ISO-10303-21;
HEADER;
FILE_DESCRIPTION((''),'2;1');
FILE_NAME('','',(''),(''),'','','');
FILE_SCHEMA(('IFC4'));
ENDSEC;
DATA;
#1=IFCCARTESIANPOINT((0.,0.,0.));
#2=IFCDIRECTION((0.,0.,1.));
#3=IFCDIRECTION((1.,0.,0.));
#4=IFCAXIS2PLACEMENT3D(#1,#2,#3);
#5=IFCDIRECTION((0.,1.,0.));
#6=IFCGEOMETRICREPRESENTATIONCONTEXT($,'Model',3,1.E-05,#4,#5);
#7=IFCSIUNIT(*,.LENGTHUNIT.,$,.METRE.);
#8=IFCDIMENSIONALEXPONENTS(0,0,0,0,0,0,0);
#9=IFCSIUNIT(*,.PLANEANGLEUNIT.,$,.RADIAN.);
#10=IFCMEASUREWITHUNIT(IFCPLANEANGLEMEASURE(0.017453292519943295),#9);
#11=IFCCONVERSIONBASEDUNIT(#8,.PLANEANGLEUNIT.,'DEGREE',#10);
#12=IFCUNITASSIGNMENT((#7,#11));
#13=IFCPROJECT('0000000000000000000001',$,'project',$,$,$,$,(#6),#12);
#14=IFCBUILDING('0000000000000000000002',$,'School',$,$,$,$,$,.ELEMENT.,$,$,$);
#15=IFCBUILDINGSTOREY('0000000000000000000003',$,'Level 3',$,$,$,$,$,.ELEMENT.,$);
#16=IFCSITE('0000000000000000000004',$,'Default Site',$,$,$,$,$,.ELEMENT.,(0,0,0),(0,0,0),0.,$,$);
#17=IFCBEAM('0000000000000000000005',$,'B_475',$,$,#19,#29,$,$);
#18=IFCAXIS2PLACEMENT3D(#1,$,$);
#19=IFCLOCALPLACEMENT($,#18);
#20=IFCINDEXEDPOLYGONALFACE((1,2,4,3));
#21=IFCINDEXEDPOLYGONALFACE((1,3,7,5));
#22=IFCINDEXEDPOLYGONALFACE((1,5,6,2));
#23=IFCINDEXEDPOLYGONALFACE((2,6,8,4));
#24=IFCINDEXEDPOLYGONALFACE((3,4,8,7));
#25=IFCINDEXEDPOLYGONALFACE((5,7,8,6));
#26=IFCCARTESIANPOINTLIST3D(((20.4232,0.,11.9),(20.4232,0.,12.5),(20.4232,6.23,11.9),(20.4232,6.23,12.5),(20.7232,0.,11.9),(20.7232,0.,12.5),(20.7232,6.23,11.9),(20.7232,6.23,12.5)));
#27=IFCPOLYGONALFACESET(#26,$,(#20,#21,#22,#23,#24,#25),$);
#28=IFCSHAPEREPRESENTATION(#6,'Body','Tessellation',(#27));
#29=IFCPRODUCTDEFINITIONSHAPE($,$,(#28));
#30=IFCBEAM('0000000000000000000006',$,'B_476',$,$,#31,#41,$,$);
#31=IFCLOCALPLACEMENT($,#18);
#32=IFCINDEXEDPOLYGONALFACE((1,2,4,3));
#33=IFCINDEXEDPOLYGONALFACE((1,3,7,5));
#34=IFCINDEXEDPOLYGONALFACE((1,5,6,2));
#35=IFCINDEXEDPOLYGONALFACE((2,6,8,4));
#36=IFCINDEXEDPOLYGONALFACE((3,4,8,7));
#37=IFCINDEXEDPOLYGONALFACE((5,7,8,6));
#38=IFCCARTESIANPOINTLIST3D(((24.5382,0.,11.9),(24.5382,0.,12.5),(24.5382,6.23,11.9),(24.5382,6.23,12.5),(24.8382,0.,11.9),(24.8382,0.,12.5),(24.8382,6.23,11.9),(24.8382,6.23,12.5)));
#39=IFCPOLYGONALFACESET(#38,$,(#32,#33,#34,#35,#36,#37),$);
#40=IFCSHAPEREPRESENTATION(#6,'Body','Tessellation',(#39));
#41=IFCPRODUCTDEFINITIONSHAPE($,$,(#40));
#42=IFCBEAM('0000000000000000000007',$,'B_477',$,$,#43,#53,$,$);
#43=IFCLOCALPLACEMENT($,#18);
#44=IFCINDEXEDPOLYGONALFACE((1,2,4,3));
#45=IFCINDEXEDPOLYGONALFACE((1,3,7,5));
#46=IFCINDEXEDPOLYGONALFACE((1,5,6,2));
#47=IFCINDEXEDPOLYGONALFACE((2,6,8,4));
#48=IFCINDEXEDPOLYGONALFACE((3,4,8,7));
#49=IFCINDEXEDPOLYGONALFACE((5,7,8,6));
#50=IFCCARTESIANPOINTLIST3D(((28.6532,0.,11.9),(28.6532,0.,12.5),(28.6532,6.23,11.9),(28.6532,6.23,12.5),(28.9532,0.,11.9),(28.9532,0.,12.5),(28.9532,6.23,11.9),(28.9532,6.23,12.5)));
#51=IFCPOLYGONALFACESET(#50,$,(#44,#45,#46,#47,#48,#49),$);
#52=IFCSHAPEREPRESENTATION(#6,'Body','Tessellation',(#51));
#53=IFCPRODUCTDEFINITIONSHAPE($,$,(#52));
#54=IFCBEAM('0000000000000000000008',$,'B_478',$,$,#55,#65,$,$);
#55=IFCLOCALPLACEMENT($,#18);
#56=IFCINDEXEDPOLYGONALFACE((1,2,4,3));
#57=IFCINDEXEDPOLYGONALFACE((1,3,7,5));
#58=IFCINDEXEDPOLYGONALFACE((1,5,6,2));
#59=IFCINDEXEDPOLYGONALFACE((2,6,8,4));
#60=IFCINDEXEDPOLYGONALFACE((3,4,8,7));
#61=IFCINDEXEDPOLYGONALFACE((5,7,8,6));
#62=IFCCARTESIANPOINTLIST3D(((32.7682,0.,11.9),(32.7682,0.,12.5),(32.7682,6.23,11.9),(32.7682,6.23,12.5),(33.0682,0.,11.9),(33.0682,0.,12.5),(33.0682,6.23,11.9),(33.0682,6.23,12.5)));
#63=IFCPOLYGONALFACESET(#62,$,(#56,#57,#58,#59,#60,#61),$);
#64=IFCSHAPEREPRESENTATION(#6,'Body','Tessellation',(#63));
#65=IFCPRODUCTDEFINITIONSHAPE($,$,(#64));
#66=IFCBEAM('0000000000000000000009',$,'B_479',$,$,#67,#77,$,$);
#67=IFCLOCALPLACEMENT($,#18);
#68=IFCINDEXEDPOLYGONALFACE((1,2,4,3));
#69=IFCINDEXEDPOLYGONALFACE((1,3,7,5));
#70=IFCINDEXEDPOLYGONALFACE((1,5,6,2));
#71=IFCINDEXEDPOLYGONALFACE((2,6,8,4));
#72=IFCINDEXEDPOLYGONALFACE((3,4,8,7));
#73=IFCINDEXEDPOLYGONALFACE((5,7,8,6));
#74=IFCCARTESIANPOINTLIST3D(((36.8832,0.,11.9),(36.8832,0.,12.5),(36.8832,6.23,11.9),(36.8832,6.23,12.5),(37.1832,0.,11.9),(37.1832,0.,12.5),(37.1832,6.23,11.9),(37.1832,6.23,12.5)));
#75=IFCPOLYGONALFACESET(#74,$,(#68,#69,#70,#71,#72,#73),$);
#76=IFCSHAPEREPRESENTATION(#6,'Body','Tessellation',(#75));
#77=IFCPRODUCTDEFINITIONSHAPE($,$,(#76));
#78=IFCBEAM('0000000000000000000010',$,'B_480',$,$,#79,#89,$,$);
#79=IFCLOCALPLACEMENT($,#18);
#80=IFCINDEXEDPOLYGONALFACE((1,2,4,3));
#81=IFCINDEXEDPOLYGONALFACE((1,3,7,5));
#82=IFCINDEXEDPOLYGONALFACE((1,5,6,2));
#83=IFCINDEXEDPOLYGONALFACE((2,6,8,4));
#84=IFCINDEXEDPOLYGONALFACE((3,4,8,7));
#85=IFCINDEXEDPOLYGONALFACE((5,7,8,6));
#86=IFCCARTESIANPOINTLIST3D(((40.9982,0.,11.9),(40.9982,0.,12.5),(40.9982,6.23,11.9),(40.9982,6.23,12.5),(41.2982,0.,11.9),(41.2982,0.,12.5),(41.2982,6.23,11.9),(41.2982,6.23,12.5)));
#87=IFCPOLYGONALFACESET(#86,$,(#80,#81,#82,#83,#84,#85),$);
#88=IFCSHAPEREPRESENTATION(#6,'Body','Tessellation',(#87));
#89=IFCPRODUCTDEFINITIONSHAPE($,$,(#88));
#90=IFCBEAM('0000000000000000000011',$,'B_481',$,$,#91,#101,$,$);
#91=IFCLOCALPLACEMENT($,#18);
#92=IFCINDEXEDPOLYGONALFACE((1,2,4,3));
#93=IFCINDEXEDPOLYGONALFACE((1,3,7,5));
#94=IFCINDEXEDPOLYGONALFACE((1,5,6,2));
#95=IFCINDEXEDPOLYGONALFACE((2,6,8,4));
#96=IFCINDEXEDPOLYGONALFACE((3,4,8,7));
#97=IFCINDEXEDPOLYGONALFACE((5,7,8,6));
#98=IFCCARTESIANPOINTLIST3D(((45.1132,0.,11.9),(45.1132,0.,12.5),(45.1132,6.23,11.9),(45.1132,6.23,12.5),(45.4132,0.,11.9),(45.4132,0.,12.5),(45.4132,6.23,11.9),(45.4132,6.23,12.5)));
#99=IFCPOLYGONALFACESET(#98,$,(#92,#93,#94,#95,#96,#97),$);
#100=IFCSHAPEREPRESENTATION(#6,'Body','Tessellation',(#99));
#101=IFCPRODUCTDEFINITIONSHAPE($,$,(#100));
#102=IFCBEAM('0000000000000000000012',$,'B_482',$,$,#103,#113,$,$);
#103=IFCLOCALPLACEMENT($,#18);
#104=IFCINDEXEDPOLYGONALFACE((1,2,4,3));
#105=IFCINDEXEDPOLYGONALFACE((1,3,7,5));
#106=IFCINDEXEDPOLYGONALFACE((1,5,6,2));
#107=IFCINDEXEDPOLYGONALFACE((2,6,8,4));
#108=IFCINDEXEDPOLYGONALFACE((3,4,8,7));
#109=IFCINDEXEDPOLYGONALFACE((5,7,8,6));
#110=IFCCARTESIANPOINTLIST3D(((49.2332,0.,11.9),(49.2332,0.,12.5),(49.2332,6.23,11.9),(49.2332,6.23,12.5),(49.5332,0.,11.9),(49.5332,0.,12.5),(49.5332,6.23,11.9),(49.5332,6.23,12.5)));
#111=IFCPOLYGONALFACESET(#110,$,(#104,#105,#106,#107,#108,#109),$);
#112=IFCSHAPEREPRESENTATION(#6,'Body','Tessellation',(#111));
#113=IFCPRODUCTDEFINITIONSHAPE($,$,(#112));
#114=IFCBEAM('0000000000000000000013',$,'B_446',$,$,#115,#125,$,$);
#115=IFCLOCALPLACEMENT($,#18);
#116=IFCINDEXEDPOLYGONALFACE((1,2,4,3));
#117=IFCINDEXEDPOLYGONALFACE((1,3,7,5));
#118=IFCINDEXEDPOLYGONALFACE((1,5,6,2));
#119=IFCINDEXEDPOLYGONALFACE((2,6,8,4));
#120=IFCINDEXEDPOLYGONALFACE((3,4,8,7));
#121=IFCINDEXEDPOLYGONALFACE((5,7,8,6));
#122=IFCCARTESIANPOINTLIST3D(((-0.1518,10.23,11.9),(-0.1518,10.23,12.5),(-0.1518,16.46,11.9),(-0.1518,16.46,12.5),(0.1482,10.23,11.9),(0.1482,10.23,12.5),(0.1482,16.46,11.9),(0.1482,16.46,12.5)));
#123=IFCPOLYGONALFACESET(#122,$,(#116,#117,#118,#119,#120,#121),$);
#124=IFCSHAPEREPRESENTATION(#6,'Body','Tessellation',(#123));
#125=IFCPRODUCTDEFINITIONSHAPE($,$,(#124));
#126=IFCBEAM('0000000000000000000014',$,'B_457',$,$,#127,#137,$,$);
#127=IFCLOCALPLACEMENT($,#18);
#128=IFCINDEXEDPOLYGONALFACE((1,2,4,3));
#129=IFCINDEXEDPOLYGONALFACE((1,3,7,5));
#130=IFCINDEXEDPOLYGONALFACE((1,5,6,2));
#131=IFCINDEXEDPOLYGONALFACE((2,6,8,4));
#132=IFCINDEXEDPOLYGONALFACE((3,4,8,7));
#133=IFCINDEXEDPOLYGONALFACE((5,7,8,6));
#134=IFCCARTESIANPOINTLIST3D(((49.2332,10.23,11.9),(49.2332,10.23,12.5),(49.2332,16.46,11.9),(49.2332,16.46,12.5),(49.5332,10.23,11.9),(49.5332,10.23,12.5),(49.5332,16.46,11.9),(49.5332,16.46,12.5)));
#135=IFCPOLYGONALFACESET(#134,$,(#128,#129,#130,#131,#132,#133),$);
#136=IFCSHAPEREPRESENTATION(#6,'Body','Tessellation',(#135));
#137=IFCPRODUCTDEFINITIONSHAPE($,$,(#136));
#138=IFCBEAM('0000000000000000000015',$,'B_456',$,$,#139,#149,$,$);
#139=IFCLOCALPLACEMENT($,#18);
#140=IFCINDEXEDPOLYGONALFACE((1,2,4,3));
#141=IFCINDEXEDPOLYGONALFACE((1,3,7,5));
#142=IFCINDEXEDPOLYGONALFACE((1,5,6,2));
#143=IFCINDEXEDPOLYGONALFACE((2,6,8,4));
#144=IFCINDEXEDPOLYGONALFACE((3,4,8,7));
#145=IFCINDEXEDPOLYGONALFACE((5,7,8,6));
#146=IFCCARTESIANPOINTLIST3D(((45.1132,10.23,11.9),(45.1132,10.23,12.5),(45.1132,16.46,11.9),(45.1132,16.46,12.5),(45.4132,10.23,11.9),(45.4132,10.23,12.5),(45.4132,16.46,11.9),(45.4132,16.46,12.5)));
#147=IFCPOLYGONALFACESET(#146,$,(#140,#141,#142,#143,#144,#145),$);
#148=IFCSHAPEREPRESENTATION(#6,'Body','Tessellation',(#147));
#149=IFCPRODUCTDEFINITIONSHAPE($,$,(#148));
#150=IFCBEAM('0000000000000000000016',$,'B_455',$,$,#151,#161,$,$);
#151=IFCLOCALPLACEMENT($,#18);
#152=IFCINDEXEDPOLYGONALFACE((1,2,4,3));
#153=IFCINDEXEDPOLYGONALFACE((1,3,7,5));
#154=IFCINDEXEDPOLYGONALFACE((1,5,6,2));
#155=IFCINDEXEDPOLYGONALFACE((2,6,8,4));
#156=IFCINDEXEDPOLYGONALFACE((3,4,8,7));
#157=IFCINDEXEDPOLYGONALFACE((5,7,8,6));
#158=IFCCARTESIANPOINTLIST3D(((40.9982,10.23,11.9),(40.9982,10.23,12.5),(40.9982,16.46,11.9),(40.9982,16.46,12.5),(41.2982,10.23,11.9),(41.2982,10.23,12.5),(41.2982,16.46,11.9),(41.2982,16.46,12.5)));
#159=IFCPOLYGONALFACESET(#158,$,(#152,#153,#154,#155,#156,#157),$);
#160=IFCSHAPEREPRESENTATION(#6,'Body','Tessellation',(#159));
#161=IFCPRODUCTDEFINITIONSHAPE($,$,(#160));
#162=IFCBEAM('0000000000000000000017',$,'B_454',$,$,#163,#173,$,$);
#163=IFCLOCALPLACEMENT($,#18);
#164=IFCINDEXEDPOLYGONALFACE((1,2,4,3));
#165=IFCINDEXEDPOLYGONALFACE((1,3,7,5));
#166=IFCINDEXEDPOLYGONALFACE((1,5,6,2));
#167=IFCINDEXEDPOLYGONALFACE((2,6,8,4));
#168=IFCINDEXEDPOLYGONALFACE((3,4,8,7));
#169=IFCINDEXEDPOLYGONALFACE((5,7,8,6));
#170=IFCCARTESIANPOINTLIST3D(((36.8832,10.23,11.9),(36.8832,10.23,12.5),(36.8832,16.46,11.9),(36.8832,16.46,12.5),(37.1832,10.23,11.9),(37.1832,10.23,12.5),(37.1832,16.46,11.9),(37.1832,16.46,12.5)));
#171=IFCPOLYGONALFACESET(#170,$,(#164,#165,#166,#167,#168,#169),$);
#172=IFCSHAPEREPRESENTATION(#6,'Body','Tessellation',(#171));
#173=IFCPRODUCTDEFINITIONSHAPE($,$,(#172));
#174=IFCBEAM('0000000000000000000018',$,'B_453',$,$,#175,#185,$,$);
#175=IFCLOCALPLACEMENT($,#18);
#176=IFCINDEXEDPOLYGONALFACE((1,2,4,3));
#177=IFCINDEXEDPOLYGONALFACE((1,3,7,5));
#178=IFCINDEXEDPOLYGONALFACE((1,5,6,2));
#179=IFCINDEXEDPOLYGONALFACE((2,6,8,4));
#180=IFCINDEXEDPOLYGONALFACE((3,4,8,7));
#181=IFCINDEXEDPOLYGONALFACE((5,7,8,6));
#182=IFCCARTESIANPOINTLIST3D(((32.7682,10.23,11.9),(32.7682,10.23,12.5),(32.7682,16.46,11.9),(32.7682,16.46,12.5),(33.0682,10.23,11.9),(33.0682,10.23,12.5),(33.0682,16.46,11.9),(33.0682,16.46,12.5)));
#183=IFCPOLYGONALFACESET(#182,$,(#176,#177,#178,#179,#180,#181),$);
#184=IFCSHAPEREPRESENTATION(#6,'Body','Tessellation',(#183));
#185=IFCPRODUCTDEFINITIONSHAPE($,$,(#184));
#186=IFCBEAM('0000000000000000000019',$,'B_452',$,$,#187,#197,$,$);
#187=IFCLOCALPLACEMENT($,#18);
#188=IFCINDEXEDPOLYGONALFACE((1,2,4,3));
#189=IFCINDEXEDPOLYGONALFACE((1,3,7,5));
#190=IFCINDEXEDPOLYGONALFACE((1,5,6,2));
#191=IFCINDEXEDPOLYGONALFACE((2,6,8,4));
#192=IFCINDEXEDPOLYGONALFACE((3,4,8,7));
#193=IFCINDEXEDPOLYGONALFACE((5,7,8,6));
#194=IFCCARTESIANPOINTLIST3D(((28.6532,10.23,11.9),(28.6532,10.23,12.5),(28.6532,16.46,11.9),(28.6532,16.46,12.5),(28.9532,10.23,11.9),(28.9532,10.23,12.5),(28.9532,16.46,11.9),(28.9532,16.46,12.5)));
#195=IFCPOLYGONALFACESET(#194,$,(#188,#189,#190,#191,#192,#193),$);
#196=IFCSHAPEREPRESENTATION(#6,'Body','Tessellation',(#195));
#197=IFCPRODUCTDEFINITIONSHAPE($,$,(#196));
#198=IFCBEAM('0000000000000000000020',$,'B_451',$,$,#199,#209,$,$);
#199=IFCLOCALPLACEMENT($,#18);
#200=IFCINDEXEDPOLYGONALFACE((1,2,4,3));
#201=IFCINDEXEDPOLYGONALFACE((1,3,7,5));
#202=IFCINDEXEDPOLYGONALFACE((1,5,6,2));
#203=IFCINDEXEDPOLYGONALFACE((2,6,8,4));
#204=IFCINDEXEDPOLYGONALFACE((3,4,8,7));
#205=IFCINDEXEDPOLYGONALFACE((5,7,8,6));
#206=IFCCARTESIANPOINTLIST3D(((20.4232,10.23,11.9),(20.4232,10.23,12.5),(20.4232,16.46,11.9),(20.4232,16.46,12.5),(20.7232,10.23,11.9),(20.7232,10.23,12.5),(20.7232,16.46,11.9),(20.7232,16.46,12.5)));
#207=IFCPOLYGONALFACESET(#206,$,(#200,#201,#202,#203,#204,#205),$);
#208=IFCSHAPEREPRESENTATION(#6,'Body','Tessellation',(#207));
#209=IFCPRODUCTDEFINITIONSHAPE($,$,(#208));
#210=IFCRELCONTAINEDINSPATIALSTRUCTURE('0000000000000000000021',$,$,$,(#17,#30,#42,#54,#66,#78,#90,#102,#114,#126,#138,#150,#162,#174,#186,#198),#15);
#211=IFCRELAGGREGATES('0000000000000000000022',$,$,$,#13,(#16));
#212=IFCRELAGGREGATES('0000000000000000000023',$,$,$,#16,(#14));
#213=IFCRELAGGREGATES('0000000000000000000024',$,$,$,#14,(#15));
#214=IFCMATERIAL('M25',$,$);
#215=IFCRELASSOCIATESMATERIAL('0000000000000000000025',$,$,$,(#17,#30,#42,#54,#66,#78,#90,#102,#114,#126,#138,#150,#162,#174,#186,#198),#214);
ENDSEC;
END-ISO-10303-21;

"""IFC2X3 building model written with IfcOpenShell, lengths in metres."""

from ifc_helpers import new_model, entity, si_unit, converted_unit, direction, frame, frame_2d, origin_with_axes, place, context, project, spatial, rectangle, extrude, material, element, save


model = new_model("IFC2X3")

# Units and contexts
model_context = context("Model", 3, precision=1e-05, world=origin_with_axes(), true_north=direction((0.0, 1.0, 0.0)))
ifc_project = project(units=[si_unit("LENGTHUNIT", "METRE"), converted_unit("PLANEANGLEUNIT", "DEGREE", entity("IfcPlaneAngleMeasure", 0.017453292519943295), si_unit("PLANEANGLEUNIT", "RADIAN"), dimensions=[0, 0, 0, 0, 0, 0, 0])], contexts=[model_context])

# Site, building, storey
site = spatial("IfcSite", under=ifc_project, Name="Default Site", CompositionType="ELEMENT", RefLatitude=(0, 0, 0), RefLongitude=(0, 0, 0), RefElevation=0.0)
building = spatial("IfcBuilding", under=site, Name="School", CompositionType="ELEMENT")
storey = spatial("IfcBuildingStorey", under=building, Name="Level 3", CompositionType="ELEMENT")

# Beams
ifc_material = material(Name="M25")
placement = place(None, origin_with_axes())
element("IfcBeam", 1, at=placement, inside=storey, material=ifc_material, Name="B_475", context=model_context, shape_type="SweptSolid", body=[
    extrude(rectangle(XDim=0.3, YDim=0.6, at=frame_2d((0.0, 0.0), x_axis=(0.0, 1.0, 0.0))), frame((20.5732, 0.0, 12.2), z_axis=(0.0, 1.0, 0.0), x_axis=(0.0, 0.0, -1.0)), (0.0, 0.0, 1.0), 6.23),
])
element("IfcBeam", 2, at=placement, inside=storey, material=ifc_material, Name="B_476", context=model_context, shape_type="SweptSolid", body=[
    extrude(rectangle(XDim=0.3, YDim=0.6, at=frame_2d((0.0, 0.0), x_axis=(0.0, 1.0, 0.0))), frame((24.6882, 0.0, 12.2), z_axis=(0.0, 1.0, 0.0), x_axis=(0.0, 0.0, -1.0)), (0.0, 0.0, 1.0), 6.23),
])
element("IfcBeam", 3, at=placement, inside=storey, material=ifc_material, Name="B_477", context=model_context, shape_type="SweptSolid", body=[
    extrude(rectangle(XDim=0.3, YDim=0.6, at=frame_2d((0.0, 0.0), x_axis=(0.0, 1.0, 0.0))), frame((28.8032, 0.0, 12.2), z_axis=(0.0, 1.0, 0.0), x_axis=(0.0, 0.0, -1.0)), (0.0, 0.0, 1.0), 6.23),
])
element("IfcBeam", 4, at=placement, inside=storey, material=ifc_material, Name="B_478", context=model_context, shape_type="SweptSolid", body=[
    extrude(rectangle(XDim=0.3, YDim=0.6, at=frame_2d((0.0, 0.0), x_axis=(0.0, 1.0, 0.0))), frame((32.9182, 0.0, 12.2), z_axis=(0.0, 1.0, 0.0), x_axis=(0.0, 0.0, -1.0)), (0.0, 0.0, 1.0), 6.23),
])
element("IfcBeam", 5, at=placement, inside=storey, material=ifc_material, Name="B_479", context=model_context, shape_type="SweptSolid", body=[
    extrude(rectangle(XDim=0.3, YDim=0.6, at=frame_2d((0.0, 0.0), x_axis=(0.0, 1.0, 0.0))), frame((37.0332, 0.0, 12.2), z_axis=(0.0, 1.0, 0.0), x_axis=(0.0, 0.0, -1.0)), (0.0, 0.0, 1.0), 6.23),
])
element("IfcBeam", 6, at=placement, inside=storey, material=ifc_material, Name="B_480", context=model_context, shape_type="SweptSolid", body=[
    extrude(rectangle(XDim=0.3, YDim=0.6, at=frame_2d((0.0, 0.0), x_axis=(0.0, 1.0, 0.0))), frame((41.1482, 0.0, 12.2), z_axis=(0.0, 1.0, 0.0), x_axis=(0.0, 0.0, -1.0)), (0.0, 0.0, 1.0), 6.23),
])
element("IfcBeam", 7, at=placement, inside=storey, material=ifc_material, Name="B_481", context=model_context, shape_type="SweptSolid", body=[
    extrude(rectangle(XDim=0.3, YDim=0.6, at=frame_2d((0.0, 0.0), x_axis=(0.0, 1.0, 0.0))), frame((45.2632, 0.0, 12.2), z_axis=(0.0, 1.0, 0.0), x_axis=(0.0, 0.0, -1.0)), (0.0, 0.0, 1.0), 6.23),
])
element("IfcBeam", 8, at=placement, inside=storey, material=ifc_material, Name="B_482", context=model_context, shape_type="SweptSolid", body=[
    extrude(rectangle(XDim=0.3, YDim=0.6, at=frame_2d((0.0, 0.0), x_axis=(0.0, 1.0, 0.0))), frame((49.3832, 0.0, 12.2), z_axis=(0.0, 1.0, 0.0), x_axis=(0.0, 0.0, -1.0)), (0.0, 0.0, 1.0), 6.23),
])
element("IfcBeam", 9, at=placement, inside=storey, material=ifc_material, Name="B_446", context=model_context, shape_type="SweptSolid", body=[
    extrude(rectangle(XDim=0.3, YDim=0.6, at=frame_2d((0.0, 0.0), x_axis=(0.0, 1.0, 0.0))), frame((-0.0018, 10.23, 12.2), z_axis=(0.0, 1.0, 0.0), x_axis=(0.0, 0.0, -1.0)), (0.0, 0.0, 1.0), 6.23),
])
element("IfcBeam", 10, at=placement, inside=storey, material=ifc_material, Name="B_457", context=model_context, shape_type="SweptSolid", body=[
    extrude(rectangle(XDim=0.3, YDim=0.6, at=frame_2d((0.0, 0.0), x_axis=(0.0, 1.0, 0.0))), frame((49.3832, 10.23, 12.2), z_axis=(0.0, 1.0, 0.0), x_axis=(0.0, 0.0, -1.0)), (0.0, 0.0, 1.0), 6.23),
])
element("IfcBeam", 11, at=placement, inside=storey, material=ifc_material, Name="B_456", context=model_context, shape_type="SweptSolid", body=[
    extrude(rectangle(XDim=0.3, YDim=0.6, at=frame_2d((0.0, 0.0), x_axis=(0.0, 1.0, 0.0))), frame((45.2632, 10.23, 12.2), z_axis=(0.0, 1.0, 0.0), x_axis=(0.0, 0.0, -1.0)), (0.0, 0.0, 1.0), 6.23),
])
element("IfcBeam", 12, at=placement, inside=storey, material=ifc_material, Name="B_455", context=model_context, shape_type="SweptSolid", body=[
    extrude(rectangle(XDim=0.3, YDim=0.6, at=frame_2d((0.0, 0.0), x_axis=(0.0, 1.0, 0.0))), frame((41.1482, 10.23, 12.2), z_axis=(0.0, 1.0, 0.0), x_axis=(0.0, 0.0, -1.0)), (0.0, 0.0, 1.0), 6.23),
])
element("IfcBeam", 13, at=placement, inside=storey, material=ifc_material, Name="B_454", context=model_context, shape_type="SweptSolid", body=[
    extrude(rectangle(XDim=0.3, YDim=0.6, at=frame_2d((0.0, 0.0), x_axis=(0.0, 1.0, 0.0))), frame((37.0332, 10.23, 12.2), z_axis=(0.0, 1.0, 0.0), x_axis=(0.0, 0.0, -1.0)), (0.0, 0.0, 1.0), 6.23),
])
element("IfcBeam", 14, at=placement, inside=storey, material=ifc_material, Name="B_453", context=model_context, shape_type="SweptSolid", body=[
    extrude(rectangle(XDim=0.3, YDim=0.6, at=frame_2d((0.0, 0.0), x_axis=(0.0, 1.0, 0.0))), frame((32.9182, 10.23, 12.2), z_axis=(0.0, 1.0, 0.0), x_axis=(0.0, 0.0, -1.0)), (0.0, 0.0, 1.0), 6.23),
])
element("IfcBeam", 15, at=placement, inside=storey, material=ifc_material, Name="B_452", context=model_context, shape_type="SweptSolid", body=[
    extrude(rectangle(XDim=0.3, YDim=0.6, at=frame_2d((0.0, 0.0), x_axis=(0.0, 1.0, 0.0))), frame((28.8032, 10.23, 12.2), z_axis=(0.0, 1.0, 0.0), x_axis=(0.0, 0.0, -1.0)), (0.0, 0.0, 1.0), 6.23),
])
element("IfcBeam", 16, at=placement, inside=storey, material=ifc_material, Name="B_451", context=model_context, shape_type="SweptSolid", body=[
    extrude(rectangle(XDim=0.3, YDim=0.6, at=frame_2d((0.0, 0.0), x_axis=(0.0, 1.0, 0.0))), frame((20.5732, 10.23, 12.2), z_axis=(0.0, 1.0, 0.0), x_axis=(0.0, 0.0, -1.0)), (0.0, 0.0, 1.0), 6.23),
])

save(model, "model.ifc")
